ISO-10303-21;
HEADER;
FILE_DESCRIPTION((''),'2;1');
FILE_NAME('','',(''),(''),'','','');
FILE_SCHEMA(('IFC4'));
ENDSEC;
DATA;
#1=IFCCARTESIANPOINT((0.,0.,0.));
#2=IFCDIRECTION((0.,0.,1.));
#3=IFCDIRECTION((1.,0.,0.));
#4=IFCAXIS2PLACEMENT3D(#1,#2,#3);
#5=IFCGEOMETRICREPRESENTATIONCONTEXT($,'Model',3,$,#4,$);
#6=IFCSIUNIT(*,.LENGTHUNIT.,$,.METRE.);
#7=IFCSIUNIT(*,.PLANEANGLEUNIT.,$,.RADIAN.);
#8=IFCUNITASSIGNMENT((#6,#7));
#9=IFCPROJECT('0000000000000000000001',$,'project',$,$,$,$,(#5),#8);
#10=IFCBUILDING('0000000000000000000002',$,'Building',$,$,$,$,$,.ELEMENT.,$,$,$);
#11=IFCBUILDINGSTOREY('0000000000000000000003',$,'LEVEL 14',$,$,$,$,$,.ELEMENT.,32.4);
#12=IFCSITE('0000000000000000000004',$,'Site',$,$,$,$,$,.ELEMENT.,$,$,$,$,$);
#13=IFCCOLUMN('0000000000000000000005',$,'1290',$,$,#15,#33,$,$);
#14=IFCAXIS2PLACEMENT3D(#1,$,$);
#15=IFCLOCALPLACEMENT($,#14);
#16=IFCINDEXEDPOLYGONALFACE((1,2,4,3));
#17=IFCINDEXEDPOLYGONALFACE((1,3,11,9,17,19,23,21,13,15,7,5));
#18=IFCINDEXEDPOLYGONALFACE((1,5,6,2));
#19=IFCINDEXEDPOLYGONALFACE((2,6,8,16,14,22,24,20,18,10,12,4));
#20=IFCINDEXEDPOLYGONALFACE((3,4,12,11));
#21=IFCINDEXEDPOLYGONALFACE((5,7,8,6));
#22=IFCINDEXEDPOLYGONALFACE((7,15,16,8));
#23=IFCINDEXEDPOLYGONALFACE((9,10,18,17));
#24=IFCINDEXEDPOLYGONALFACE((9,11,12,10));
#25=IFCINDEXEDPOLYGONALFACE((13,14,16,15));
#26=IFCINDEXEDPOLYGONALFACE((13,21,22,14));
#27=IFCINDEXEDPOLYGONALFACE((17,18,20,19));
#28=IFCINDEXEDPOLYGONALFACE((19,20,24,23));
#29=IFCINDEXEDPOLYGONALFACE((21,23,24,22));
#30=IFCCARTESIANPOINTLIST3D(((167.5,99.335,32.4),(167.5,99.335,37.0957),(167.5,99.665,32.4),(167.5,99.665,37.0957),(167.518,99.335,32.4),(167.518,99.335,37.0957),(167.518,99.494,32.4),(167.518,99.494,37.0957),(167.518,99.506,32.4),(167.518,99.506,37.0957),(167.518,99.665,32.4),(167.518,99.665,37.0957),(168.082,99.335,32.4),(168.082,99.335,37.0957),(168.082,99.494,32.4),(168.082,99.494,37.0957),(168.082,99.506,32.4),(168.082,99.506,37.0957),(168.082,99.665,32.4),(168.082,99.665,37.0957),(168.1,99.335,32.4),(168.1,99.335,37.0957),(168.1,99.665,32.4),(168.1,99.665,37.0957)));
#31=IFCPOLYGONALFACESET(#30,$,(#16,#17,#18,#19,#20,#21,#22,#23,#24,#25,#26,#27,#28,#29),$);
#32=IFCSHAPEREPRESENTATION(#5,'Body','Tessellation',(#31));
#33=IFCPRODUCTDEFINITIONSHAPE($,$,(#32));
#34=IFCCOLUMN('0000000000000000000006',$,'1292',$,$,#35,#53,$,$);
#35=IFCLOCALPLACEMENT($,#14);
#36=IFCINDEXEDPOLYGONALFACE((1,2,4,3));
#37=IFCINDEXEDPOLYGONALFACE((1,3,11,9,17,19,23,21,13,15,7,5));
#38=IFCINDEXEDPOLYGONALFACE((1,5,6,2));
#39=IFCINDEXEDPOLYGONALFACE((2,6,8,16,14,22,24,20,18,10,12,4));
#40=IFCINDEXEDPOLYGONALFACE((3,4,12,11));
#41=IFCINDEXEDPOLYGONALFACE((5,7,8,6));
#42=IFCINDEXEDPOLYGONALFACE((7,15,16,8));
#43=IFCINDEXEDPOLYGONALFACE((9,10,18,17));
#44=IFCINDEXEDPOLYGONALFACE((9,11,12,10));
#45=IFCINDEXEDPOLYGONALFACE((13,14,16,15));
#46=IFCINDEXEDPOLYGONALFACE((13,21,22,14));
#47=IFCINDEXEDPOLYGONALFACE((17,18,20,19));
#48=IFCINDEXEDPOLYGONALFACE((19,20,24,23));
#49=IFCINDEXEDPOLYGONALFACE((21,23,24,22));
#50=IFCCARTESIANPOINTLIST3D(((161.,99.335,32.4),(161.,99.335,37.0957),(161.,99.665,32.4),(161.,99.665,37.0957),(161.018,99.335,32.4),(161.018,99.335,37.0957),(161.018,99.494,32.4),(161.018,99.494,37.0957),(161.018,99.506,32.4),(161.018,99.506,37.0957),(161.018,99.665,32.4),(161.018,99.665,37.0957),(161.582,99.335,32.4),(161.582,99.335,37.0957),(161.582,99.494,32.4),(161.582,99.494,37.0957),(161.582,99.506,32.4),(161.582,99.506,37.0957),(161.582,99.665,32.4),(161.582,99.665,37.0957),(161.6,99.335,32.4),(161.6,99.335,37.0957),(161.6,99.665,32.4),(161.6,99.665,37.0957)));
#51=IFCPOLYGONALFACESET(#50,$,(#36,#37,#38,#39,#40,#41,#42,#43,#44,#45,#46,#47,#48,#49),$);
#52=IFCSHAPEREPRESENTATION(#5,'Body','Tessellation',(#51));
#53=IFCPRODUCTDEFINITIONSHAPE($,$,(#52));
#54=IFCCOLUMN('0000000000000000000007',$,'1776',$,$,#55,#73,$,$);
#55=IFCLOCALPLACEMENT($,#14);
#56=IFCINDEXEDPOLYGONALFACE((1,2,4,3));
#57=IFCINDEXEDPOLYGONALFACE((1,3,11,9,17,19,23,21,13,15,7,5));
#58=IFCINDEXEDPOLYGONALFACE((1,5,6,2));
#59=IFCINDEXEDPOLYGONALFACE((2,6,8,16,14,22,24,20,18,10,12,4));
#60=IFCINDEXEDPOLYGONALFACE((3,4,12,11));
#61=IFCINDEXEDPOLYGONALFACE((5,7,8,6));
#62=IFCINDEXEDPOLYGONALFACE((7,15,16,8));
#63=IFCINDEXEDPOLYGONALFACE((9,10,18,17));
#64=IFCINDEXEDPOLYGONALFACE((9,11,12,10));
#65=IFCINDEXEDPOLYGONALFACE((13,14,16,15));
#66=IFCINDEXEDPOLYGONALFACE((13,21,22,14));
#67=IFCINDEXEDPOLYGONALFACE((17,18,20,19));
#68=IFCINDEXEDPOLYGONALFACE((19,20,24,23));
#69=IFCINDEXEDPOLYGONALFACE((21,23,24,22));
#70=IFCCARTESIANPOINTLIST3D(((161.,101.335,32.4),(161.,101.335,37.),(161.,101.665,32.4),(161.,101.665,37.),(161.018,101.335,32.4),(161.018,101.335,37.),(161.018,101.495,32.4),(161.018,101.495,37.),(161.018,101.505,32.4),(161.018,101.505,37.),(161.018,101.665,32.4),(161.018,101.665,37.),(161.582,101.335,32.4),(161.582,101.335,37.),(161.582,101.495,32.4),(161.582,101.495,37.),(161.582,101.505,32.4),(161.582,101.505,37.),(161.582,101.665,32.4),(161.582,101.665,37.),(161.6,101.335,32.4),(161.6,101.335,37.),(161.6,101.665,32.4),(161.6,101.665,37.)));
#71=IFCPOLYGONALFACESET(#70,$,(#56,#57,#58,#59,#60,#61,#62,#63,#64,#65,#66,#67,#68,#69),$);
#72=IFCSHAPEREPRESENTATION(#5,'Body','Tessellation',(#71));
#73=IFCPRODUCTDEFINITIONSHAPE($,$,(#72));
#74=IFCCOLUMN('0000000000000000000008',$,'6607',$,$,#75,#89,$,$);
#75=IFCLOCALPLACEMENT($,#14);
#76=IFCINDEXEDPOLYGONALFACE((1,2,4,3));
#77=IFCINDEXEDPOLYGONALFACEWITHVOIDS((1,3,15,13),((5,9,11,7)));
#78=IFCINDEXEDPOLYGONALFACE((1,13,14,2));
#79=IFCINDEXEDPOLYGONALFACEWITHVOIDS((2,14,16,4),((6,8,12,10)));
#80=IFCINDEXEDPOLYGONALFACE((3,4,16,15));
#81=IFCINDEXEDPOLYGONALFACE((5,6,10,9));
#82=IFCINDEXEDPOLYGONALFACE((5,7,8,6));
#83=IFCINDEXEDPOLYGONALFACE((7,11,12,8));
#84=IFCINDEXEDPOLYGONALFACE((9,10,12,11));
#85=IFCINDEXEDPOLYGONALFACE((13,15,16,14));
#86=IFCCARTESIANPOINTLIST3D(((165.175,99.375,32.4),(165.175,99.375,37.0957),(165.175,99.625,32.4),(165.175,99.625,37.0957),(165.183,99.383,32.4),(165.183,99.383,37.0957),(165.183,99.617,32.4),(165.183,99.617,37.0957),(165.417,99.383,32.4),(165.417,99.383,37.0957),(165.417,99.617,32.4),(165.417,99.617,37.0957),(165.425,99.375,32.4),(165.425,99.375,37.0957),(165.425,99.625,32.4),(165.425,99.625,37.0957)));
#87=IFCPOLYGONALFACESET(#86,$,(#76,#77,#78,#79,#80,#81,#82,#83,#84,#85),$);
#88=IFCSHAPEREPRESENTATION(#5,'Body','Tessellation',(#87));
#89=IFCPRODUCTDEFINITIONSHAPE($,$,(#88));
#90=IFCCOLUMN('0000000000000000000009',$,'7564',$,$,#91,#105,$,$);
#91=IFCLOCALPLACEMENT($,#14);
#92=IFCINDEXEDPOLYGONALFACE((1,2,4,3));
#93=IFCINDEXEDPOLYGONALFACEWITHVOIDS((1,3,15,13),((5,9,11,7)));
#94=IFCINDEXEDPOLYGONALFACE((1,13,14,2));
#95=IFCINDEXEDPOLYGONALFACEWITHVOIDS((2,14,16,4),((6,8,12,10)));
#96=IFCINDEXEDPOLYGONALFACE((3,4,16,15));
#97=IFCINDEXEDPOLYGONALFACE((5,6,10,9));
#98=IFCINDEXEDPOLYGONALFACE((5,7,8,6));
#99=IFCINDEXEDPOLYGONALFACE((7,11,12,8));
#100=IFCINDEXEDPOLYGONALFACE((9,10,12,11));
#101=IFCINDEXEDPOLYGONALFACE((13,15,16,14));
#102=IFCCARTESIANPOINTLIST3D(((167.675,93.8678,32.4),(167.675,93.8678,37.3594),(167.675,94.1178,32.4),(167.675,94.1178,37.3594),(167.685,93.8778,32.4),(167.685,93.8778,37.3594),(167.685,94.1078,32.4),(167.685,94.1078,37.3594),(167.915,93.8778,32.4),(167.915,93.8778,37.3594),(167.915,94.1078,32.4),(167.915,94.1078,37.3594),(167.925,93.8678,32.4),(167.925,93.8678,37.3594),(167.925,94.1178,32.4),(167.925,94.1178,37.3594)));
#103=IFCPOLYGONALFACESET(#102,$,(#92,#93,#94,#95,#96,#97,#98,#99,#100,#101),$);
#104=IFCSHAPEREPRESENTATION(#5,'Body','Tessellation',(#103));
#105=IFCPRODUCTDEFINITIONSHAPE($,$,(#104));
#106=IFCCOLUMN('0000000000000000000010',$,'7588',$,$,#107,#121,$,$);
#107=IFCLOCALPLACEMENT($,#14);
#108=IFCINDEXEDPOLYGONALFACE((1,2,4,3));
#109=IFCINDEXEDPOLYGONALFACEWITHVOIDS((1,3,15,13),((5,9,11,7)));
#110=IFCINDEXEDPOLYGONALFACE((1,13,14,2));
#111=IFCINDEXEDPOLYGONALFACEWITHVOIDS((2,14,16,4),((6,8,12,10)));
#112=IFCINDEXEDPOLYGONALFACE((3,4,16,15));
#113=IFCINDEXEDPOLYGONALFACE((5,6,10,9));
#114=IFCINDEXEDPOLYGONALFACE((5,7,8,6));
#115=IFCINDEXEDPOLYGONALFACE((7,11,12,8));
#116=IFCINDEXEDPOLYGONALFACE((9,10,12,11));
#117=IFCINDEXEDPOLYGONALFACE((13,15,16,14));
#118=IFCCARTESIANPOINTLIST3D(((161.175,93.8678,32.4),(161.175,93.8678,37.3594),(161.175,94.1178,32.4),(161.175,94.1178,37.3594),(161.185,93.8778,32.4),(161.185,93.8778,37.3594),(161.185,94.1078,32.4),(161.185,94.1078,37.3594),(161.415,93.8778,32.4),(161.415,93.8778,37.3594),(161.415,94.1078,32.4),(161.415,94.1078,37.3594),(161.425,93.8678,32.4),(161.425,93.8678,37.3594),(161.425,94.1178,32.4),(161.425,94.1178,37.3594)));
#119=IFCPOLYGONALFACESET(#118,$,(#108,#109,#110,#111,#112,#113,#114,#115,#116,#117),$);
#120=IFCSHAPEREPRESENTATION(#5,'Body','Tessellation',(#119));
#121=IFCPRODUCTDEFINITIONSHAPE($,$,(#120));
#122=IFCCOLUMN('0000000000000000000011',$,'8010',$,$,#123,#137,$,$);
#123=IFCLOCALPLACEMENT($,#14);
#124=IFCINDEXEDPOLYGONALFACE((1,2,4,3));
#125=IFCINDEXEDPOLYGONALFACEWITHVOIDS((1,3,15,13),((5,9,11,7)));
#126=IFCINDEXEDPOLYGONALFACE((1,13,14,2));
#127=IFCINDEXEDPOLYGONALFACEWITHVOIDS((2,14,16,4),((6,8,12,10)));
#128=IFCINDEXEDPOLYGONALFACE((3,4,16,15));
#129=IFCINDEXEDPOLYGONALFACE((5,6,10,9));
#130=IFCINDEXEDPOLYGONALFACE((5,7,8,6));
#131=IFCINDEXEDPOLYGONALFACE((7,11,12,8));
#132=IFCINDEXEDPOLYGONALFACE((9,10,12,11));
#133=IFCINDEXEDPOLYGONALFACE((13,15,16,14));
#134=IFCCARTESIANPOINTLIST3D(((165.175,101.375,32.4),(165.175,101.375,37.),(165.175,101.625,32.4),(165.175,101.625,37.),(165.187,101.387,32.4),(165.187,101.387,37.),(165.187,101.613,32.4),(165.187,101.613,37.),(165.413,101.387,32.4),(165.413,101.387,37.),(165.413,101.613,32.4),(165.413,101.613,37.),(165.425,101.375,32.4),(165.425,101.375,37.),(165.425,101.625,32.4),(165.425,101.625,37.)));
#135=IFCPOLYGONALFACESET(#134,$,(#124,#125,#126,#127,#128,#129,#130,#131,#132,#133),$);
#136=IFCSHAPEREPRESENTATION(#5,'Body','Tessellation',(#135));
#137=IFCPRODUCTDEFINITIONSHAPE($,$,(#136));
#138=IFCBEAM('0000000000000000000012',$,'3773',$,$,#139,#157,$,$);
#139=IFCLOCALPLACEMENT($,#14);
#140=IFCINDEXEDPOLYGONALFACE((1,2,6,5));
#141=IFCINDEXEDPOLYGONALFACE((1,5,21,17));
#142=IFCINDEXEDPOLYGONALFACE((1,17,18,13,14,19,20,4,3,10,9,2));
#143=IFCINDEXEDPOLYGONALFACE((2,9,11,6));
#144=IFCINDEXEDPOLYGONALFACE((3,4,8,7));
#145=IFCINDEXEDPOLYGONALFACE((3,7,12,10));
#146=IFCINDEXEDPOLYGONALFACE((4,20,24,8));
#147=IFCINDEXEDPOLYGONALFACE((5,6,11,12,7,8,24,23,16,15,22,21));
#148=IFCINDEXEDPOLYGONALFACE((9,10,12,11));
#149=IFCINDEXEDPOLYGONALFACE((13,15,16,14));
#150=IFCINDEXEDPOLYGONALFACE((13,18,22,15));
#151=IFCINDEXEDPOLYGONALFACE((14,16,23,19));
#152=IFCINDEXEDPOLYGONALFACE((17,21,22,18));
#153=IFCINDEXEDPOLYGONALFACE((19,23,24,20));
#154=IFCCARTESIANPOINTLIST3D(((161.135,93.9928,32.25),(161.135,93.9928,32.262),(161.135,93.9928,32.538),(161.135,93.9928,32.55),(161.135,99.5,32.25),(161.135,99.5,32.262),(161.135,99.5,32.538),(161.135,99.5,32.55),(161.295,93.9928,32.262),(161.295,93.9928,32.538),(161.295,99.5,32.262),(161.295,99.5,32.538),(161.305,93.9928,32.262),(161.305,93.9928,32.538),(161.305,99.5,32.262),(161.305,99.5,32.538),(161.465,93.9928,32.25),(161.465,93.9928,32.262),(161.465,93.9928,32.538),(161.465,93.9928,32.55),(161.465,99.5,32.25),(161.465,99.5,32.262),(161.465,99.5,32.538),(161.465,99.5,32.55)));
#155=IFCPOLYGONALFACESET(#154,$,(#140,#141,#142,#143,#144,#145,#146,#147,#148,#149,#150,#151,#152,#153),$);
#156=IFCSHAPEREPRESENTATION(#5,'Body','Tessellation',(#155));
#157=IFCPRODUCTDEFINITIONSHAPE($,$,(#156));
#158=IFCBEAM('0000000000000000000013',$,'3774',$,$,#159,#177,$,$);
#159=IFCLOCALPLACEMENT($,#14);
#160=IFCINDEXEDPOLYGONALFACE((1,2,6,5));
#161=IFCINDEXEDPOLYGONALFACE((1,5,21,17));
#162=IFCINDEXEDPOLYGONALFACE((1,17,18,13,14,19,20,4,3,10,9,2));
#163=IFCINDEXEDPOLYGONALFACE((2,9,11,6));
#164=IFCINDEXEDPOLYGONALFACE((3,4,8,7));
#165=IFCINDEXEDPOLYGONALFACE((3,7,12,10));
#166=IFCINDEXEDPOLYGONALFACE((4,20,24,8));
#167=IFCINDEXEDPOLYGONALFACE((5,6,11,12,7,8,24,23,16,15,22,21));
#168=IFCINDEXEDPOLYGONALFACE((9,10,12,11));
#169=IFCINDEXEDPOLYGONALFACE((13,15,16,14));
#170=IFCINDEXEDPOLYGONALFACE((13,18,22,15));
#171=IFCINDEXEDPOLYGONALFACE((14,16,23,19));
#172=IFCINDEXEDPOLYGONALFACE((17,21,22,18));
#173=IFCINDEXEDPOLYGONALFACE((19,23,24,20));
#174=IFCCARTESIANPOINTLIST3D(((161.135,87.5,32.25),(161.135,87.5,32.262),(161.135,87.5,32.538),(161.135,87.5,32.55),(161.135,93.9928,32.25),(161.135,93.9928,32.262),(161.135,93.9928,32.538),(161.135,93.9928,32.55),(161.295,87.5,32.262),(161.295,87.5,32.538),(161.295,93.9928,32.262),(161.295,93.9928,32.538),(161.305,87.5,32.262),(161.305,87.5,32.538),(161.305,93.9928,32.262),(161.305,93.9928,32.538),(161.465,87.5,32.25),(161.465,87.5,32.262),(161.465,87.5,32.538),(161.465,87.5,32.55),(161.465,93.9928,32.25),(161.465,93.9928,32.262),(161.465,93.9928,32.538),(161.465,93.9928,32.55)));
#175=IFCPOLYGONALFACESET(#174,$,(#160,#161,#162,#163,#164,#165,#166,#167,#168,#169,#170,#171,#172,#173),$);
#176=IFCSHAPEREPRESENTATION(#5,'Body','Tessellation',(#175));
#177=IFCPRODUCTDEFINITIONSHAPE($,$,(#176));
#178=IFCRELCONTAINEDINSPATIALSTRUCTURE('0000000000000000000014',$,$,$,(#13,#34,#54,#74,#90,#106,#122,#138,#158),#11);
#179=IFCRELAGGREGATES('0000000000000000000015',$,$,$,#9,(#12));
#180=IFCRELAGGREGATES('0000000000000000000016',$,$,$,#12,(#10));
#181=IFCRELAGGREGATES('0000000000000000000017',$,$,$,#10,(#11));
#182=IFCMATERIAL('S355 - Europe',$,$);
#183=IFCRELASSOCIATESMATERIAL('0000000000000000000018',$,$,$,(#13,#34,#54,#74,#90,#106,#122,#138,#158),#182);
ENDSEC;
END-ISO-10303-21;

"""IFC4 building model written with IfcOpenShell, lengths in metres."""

from ifc_helpers import new_model, si_unit, frame, origin_with_axes, origin_2d_with_axis, place, context, project, spatial, hollow_rectangle, i_section, extrude, material, material_profile, profile_set, profile_usage, element, save


model = new_model("IFC4")

# Units and contexts
model_context = context("Model", 3, world=origin_with_axes())
ifc_project = project(units=[si_unit("LENGTHUNIT", "METRE"), si_unit("PLANEANGLEUNIT", "RADIAN")], contexts=[model_context])

# Site, building, storey
site = spatial("IfcSite", under=ifc_project, Name="Site", CompositionType="ELEMENT")
building = spatial("IfcBuilding", under=site, Name="Building", CompositionType="ELEMENT")
storey = spatial("IfcBuildingStorey", under=building, Name="LEVEL 14", CompositionType="ELEMENT", Elevation=32.4)

# Columns
ifc_material = material(Name="S355 - Europe")
ifc_material_profile_1 = material_profile(ifc_material, i_section(OverallWidth=0.33, OverallDepth=0.6, WebThickness=0.012, FlangeThickness=0.018, at=origin_2d_with_axis()))
ifc_profile_set_1 = profile_set([ifc_material_profile_1])
ifc_profile_usage_1 = profile_usage(ifc_profile_set_1, cardinal=10)
column_1_placement = place(None, frame((167.8, 99.5, 32.4), z_axis=(0.0, 0.0, 1.0), x_axis=(0.0, -1.0, 0.0)))
element("IfcColumn", 1, at=column_1_placement, inside=storey, material=ifc_profile_usage_1, Name="1290", context=model_context, shape_type="SweptSolid", body=[
    extrude(i_section(OverallWidth=0.33, OverallDepth=0.6, WebThickness=0.012, FlangeThickness=0.018, at=origin_2d_with_axis()), origin_with_axes(), (0.0, 0.0, 1.0), 4.6957),
])
ifc_material_profile_2 = material_profile(ifc_material, i_section(OverallWidth=0.33, OverallDepth=0.6, WebThickness=0.012, FlangeThickness=0.018, at=origin_2d_with_axis()))
ifc_profile_set_2 = profile_set([ifc_material_profile_2])
ifc_profile_usage_2 = profile_usage(ifc_profile_set_2, cardinal=10)
column_2_placement = place(None, frame((161.3, 99.5, 32.4), z_axis=(0.0, 0.0, 1.0), x_axis=(0.0, -1.0, 0.0)))
element("IfcColumn", 2, at=column_2_placement, inside=storey, material=ifc_profile_usage_2, Name="1292", context=model_context, shape_type="SweptSolid", body=[
    extrude(i_section(OverallWidth=0.33, OverallDepth=0.6, WebThickness=0.012, FlangeThickness=0.018, at=origin_2d_with_axis()), origin_with_axes(), (0.0, 0.0, 1.0), 4.6957),
])
ifc_material_profile_3 = material_profile(ifc_material, i_section(OverallWidth=0.33, OverallDepth=0.6, WebThickness=0.01, FlangeThickness=0.018, at=origin_2d_with_axis()))
ifc_profile_set_3 = profile_set([ifc_material_profile_3])
ifc_profile_usage_3 = profile_usage(ifc_profile_set_3, cardinal=10)
column_3_placement = place(None, frame((161.3, 101.5, 32.4), z_axis=(0.0, 0.0, 1.0), x_axis=(0.0, -1.0, 0.0)))
element("IfcColumn", 3, at=column_3_placement, inside=storey, material=ifc_profile_usage_3, Name="1776", context=model_context, shape_type="SweptSolid", body=[
    extrude(i_section(OverallWidth=0.33, OverallDepth=0.6, WebThickness=0.01, FlangeThickness=0.018, at=origin_2d_with_axis()), origin_with_axes(), (0.0, 0.0, 1.0), 4.6),
])
ifc_material_profile_4 = material_profile(ifc_material, hollow_rectangle(XDim=0.25, YDim=0.25, WallThickness=0.008, at=origin_2d_with_axis()))
ifc_profile_set_4 = profile_set([ifc_material_profile_4])
ifc_profile_usage_4 = profile_usage(ifc_profile_set_4, cardinal=10)
column_4_placement = place(None, frame((165.3, 99.5, 32.4), z_axis=(0.0, 0.0, 1.0), x_axis=(0.0, -1.0, 0.0)))
element("IfcColumn", 4, at=column_4_placement, inside=storey, material=ifc_profile_usage_4, Name="6607", context=model_context, shape_type="SweptSolid", body=[
    extrude(hollow_rectangle(XDim=0.25, YDim=0.25, WallThickness=0.008, at=origin_2d_with_axis()), origin_with_axes(), (0.0, 0.0, 1.0), 4.6957),
])
ifc_material_profile_5 = material_profile(ifc_material, hollow_rectangle(XDim=0.25, YDim=0.25, WallThickness=0.01, at=origin_2d_with_axis()))
ifc_profile_set_5 = profile_set([ifc_material_profile_5])
ifc_profile_usage_5 = profile_usage(ifc_profile_set_5, cardinal=10)
column_5_placement = place(None, frame((167.8, 93.9928, 32.4), z_axis=(0.0, 0.0, 1.0), x_axis=(0.0, -1.0, 0.0)))
element("IfcColumn", 5, at=column_5_placement, inside=storey, material=ifc_profile_usage_5, Name="7564", context=model_context, shape_type="SweptSolid", body=[
    extrude(hollow_rectangle(XDim=0.25, YDim=0.25, WallThickness=0.01, at=origin_2d_with_axis()), origin_with_axes(), (0.0, 0.0, 1.0), 4.9594),
])
ifc_material_profile_6 = material_profile(ifc_material, hollow_rectangle(XDim=0.25, YDim=0.25, WallThickness=0.01, at=origin_2d_with_axis()))
ifc_profile_set_6 = profile_set([ifc_material_profile_6])
ifc_profile_usage_6 = profile_usage(ifc_profile_set_6, cardinal=10)
column_6_placement = place(None, frame((161.3, 93.9928, 32.4), z_axis=(0.0, 0.0, 1.0), x_axis=(0.0, -1.0, 0.0)))
element("IfcColumn", 6, at=column_6_placement, inside=storey, material=ifc_profile_usage_6, Name="7588", context=model_context, shape_type="SweptSolid", body=[
    extrude(hollow_rectangle(XDim=0.25, YDim=0.25, WallThickness=0.01, at=origin_2d_with_axis()), origin_with_axes(), (0.0, 0.0, 1.0), 4.9594),
])
ifc_material_profile_7 = material_profile(ifc_material, hollow_rectangle(XDim=0.25, YDim=0.25, WallThickness=0.012, at=origin_2d_with_axis()))
ifc_profile_set_7 = profile_set([ifc_material_profile_7])
ifc_profile_usage_7 = profile_usage(ifc_profile_set_7, cardinal=10)
column_7_placement = place(None, frame((165.3, 101.5, 32.4), z_axis=(0.0, 0.0, 1.0), x_axis=(0.0, -1.0, 0.0)))
element("IfcColumn", 7, at=column_7_placement, inside=storey, material=ifc_profile_usage_7, Name="8010", context=model_context, shape_type="SweptSolid", body=[
    extrude(hollow_rectangle(XDim=0.25, YDim=0.25, WallThickness=0.012, at=origin_2d_with_axis()), origin_with_axes(), (0.0, 0.0, 1.0), 4.6),
])

# Beams
ifc_material_profile_8 = material_profile(ifc_material, i_section(OverallWidth=0.33, OverallDepth=0.3, WebThickness=0.01, FlangeThickness=0.012, at=origin_2d_with_axis()))
ifc_profile_set_8 = profile_set([ifc_material_profile_8])
ifc_profile_usage_8 = profile_usage(ifc_profile_set_8, cardinal=10)
beam_1_placement = place(None, frame((161.3, 93.9928, 32.4), z_axis=(0.0, 1.0, 0.0), x_axis=(-1.0, 0.0, 0.0)))
element("IfcBeam", 8, at=beam_1_placement, inside=storey, material=ifc_profile_usage_8, Name="3773", context=model_context, shape_type="SweptSolid", body=[
    extrude(i_section(OverallWidth=0.33, OverallDepth=0.3, WebThickness=0.01, FlangeThickness=0.012, at=origin_2d_with_axis()), origin_with_axes(), (0.0, 0.0, 1.0), 5.5072),
])
ifc_material_profile_9 = material_profile(ifc_material, i_section(OverallWidth=0.33, OverallDepth=0.3, WebThickness=0.01, FlangeThickness=0.012, at=origin_2d_with_axis()))
ifc_profile_set_9 = profile_set([ifc_material_profile_9])
ifc_profile_usage_9 = profile_usage(ifc_profile_set_9, cardinal=10)
beam_2_placement = place(None, frame((161.3, 93.9928, 32.4), z_axis=(0.0, -1.0, 0.0), x_axis=(1.0, 0.0, 0.0)))
element("IfcBeam", 9, at=beam_2_placement, inside=storey, material=ifc_profile_usage_9, Name="3774", context=model_context, shape_type="SweptSolid", body=[
    extrude(i_section(OverallWidth=0.33, OverallDepth=0.3, WebThickness=0.01, FlangeThickness=0.012, at=origin_2d_with_axis()), origin_with_axes(), (0.0, 0.0, 1.0), 6.4928),
])

save(model, "model.ifc")
